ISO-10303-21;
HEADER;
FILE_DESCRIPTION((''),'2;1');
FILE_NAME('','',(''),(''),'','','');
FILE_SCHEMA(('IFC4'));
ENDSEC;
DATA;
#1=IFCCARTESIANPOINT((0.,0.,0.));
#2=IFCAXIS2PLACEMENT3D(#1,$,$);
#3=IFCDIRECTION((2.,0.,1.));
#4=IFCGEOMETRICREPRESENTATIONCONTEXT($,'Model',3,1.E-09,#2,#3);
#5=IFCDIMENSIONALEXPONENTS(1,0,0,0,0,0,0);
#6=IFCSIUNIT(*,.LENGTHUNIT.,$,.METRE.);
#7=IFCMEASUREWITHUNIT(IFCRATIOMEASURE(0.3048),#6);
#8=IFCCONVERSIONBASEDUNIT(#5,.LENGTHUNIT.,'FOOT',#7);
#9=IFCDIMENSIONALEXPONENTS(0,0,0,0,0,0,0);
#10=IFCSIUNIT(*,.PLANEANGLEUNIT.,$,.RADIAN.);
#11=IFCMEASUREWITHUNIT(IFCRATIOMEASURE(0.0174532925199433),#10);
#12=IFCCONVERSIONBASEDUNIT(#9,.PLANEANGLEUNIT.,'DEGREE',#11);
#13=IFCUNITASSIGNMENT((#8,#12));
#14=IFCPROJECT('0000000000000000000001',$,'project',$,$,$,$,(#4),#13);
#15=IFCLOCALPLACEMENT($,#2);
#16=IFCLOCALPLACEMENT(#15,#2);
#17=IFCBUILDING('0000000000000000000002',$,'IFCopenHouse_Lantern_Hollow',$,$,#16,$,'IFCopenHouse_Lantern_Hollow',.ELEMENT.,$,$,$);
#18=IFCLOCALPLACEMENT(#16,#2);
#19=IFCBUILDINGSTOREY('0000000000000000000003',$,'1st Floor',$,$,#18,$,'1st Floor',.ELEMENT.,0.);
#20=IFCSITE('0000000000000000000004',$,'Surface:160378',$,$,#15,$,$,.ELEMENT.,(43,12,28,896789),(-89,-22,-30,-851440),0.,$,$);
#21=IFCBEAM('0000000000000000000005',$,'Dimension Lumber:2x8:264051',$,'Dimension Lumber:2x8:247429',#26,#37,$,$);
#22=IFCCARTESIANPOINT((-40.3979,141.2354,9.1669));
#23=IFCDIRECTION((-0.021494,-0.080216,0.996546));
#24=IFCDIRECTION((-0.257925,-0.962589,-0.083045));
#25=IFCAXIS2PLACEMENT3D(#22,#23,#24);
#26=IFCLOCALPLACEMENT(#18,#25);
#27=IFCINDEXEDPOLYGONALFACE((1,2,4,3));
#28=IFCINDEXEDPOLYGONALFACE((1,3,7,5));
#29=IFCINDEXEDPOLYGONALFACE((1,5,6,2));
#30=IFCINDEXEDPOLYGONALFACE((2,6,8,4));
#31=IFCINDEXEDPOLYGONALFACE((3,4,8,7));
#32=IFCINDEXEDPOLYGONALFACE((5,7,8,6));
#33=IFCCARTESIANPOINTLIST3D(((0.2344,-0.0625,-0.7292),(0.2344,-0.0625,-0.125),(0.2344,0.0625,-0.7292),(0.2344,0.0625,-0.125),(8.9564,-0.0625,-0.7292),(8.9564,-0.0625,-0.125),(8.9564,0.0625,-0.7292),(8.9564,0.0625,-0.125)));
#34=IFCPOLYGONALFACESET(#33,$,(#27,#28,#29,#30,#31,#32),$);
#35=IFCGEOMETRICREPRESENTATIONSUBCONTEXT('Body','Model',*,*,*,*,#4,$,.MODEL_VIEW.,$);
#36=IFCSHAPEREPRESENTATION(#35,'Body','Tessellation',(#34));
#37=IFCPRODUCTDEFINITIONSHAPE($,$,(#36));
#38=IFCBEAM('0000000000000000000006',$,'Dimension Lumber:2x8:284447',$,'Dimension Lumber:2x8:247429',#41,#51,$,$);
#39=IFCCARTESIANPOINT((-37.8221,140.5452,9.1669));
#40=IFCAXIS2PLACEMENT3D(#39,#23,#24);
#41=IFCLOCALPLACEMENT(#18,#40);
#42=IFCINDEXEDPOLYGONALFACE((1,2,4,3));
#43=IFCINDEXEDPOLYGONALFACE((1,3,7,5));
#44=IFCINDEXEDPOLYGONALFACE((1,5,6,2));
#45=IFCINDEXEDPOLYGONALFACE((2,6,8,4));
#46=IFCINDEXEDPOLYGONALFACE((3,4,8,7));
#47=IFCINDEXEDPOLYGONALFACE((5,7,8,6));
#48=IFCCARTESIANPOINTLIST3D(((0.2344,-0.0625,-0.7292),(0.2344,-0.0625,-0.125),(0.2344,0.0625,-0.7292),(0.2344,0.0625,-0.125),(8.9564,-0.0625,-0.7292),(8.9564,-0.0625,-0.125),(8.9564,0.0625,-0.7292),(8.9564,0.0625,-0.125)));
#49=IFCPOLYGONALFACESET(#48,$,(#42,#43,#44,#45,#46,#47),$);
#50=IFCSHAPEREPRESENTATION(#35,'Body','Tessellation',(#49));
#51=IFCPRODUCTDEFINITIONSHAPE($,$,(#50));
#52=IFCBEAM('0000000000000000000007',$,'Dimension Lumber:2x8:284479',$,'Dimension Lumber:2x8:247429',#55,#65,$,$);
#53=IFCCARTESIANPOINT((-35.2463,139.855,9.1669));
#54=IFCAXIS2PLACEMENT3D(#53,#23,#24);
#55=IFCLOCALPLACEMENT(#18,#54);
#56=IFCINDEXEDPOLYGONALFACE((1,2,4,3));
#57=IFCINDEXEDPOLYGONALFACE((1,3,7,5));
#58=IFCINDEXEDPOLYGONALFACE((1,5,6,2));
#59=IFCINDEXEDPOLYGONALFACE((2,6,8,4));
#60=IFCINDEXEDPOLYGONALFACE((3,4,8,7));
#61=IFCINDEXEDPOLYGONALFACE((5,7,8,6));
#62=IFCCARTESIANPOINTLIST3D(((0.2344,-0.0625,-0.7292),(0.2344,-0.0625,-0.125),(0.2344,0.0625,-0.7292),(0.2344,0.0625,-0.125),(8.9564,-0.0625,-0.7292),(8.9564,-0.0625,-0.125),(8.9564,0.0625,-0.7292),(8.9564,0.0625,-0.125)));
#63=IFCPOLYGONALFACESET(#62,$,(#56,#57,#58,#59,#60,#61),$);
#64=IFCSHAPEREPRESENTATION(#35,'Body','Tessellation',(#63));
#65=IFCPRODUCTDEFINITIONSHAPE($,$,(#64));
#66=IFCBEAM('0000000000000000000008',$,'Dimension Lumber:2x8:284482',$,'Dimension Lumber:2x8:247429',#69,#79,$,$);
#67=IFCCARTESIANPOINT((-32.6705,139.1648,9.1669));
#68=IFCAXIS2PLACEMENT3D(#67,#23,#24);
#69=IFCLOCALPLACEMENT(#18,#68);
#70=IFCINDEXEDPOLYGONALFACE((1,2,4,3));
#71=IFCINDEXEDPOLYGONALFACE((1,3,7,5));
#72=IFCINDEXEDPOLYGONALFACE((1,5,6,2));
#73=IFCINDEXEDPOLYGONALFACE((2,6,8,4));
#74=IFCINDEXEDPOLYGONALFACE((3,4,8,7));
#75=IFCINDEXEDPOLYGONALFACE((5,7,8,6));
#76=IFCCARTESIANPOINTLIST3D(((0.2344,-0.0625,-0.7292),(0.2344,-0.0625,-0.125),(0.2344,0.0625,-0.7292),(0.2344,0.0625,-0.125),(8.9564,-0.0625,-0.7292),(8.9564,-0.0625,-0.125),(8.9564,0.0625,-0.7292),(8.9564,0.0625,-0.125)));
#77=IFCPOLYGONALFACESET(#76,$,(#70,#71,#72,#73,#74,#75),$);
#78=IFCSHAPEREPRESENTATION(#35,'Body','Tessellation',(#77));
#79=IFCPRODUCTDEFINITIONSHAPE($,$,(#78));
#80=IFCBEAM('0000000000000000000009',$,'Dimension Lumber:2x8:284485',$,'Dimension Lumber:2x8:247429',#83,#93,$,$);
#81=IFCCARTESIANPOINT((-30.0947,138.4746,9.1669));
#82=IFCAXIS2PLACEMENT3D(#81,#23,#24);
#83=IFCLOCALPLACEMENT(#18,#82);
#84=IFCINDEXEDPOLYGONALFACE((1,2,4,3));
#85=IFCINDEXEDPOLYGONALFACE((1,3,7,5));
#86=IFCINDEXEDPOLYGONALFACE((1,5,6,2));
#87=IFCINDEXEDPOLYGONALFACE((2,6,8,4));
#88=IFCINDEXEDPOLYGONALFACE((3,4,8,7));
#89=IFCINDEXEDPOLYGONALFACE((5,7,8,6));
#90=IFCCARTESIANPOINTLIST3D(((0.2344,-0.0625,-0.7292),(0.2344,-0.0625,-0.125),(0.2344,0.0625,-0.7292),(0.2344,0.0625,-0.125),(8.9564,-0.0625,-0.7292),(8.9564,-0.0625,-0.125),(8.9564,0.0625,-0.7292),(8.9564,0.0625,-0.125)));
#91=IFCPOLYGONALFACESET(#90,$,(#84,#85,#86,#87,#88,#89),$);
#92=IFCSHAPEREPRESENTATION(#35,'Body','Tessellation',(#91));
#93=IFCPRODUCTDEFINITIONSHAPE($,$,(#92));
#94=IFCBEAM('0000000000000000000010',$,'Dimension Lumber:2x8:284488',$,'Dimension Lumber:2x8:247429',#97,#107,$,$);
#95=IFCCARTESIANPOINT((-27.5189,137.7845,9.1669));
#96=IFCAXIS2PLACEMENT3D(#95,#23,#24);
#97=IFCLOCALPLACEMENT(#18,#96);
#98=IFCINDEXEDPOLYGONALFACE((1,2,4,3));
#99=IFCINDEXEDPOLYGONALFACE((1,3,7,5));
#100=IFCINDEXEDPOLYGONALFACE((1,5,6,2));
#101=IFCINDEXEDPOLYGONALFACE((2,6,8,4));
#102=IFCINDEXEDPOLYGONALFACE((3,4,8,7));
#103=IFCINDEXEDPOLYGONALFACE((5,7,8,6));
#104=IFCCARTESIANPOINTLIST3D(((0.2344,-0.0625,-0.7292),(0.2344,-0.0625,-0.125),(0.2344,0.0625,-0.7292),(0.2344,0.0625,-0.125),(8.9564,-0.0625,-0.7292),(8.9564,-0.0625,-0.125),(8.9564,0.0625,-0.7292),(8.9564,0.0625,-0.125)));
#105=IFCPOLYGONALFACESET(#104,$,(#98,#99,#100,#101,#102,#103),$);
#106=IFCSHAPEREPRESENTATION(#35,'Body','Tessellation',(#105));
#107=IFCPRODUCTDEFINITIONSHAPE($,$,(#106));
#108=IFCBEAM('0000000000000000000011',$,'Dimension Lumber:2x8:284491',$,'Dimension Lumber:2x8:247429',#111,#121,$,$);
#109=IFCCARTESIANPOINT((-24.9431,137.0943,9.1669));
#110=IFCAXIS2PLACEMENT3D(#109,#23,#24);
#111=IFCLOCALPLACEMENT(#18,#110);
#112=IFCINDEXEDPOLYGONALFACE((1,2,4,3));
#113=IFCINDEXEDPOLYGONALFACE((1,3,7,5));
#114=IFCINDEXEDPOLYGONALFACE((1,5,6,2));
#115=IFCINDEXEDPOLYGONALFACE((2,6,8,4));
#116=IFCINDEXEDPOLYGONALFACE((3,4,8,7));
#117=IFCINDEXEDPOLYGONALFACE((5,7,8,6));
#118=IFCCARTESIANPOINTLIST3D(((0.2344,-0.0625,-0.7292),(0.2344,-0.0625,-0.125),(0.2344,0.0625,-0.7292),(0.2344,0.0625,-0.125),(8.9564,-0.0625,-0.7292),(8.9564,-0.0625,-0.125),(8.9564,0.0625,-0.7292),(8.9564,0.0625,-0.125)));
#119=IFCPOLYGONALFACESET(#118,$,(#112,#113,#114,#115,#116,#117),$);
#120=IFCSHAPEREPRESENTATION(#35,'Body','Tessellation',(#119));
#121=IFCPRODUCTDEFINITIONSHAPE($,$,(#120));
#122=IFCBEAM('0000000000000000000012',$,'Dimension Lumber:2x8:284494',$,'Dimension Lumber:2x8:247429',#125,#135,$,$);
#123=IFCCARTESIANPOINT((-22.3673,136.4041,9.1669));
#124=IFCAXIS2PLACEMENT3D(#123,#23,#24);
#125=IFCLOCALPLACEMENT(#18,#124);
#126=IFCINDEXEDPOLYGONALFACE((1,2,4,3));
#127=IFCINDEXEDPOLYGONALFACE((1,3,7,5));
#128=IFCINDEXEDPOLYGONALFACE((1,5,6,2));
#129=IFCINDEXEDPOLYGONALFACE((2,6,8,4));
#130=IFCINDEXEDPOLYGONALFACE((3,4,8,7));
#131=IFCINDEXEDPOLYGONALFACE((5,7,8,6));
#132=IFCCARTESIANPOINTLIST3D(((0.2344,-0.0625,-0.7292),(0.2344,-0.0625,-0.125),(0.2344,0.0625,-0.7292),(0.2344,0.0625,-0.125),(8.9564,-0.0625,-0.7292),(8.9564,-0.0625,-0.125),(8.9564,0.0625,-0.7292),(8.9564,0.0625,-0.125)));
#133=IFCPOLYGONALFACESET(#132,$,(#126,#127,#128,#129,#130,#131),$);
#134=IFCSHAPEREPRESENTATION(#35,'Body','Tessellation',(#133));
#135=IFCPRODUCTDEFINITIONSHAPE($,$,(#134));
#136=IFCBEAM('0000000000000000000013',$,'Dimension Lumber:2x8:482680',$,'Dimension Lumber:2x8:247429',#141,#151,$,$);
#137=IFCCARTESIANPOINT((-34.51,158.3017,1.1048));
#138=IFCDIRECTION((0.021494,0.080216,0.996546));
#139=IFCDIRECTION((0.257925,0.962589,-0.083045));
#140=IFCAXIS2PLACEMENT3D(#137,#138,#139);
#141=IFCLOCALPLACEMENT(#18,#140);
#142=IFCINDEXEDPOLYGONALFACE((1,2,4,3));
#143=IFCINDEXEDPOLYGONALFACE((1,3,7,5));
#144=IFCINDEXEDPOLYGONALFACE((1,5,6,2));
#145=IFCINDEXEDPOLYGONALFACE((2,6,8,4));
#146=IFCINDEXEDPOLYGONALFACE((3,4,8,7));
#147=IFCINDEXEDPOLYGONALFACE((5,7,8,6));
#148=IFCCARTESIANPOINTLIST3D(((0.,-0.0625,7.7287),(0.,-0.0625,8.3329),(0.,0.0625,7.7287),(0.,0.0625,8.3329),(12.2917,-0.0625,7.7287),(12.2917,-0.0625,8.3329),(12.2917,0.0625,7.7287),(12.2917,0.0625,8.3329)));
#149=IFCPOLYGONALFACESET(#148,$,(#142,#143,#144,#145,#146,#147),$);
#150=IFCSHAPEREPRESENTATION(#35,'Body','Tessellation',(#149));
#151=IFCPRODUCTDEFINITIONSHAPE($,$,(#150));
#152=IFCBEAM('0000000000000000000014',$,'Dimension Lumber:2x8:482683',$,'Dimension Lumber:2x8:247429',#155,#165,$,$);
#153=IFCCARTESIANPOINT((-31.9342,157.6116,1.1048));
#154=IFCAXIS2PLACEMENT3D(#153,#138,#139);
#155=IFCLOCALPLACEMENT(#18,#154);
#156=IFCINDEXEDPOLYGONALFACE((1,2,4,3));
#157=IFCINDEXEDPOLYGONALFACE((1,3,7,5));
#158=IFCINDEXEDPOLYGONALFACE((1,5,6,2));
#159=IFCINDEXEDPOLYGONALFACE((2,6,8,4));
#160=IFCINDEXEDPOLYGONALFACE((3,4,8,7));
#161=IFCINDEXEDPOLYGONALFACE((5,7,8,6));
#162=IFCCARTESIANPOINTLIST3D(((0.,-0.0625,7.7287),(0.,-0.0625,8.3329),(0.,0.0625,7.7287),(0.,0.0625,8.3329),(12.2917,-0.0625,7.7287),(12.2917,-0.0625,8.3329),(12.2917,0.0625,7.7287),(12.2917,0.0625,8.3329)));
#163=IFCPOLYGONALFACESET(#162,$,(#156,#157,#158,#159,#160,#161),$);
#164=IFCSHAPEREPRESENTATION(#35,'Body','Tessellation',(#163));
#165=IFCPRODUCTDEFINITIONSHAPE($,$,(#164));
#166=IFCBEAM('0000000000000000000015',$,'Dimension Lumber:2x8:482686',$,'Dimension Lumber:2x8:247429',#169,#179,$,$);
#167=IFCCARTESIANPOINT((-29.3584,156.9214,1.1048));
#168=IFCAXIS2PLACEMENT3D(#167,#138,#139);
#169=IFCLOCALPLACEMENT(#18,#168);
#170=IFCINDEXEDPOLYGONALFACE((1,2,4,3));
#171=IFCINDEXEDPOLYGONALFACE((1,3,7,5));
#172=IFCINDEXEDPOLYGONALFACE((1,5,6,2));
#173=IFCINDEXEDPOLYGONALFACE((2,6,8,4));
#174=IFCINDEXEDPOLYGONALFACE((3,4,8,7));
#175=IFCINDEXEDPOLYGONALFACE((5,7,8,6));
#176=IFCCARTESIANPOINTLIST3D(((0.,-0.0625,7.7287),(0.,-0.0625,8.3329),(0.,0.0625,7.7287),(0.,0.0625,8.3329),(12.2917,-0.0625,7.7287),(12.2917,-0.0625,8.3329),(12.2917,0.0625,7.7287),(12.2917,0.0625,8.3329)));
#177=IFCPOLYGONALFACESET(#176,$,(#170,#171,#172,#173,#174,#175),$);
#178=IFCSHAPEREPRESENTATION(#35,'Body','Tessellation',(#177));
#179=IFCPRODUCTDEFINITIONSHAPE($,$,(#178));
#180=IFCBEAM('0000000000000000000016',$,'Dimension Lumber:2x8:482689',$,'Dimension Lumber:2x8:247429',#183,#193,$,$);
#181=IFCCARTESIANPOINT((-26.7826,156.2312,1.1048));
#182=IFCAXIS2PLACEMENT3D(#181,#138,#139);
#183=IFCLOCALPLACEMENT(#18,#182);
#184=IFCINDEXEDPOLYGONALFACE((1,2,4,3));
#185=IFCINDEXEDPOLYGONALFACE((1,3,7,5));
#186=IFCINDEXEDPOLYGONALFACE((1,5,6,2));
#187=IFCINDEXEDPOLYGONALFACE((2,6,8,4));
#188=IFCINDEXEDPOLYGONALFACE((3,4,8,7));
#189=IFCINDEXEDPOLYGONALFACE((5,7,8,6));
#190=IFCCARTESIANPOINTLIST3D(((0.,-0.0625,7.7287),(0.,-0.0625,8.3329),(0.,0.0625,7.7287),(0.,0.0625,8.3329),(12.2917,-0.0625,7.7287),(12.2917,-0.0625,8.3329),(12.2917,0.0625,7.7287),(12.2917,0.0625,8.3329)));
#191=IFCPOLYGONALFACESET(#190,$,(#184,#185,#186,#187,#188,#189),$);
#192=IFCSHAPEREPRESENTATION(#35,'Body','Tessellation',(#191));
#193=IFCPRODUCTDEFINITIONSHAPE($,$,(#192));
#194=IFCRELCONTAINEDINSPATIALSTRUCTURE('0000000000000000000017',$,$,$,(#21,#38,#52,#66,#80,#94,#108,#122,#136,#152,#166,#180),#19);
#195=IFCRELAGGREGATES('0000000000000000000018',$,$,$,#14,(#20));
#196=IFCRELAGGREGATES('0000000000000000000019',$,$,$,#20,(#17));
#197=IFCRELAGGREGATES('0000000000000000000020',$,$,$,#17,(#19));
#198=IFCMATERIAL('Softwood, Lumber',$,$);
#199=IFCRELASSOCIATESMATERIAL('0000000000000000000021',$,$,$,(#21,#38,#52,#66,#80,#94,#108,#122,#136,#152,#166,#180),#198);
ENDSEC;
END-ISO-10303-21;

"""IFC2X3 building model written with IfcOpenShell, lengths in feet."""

from ifc_helpers import new_model, entity, si_unit, converted_unit, direction, frame, frame_2d, origin, place, context, subcontext, project, spatial, rectangle, extrude, material, element, save


model = new_model("IFC2X3")

# Units and contexts
model_context = context("Model", 3, precision=1e-09, world=origin(), true_north=direction((2.0, 0.0, 1.0)))
body_context = subcontext(model_context, "Body", "Model", "MODEL_VIEW")
ifc_project = project(units=[converted_unit("LENGTHUNIT", "FOOT", entity("IfcRatioMeasure", 0.3048), si_unit("LENGTHUNIT", "METRE"), dimensions=[1, 0, 0, 0, 0, 0, 0]), converted_unit("PLANEANGLEUNIT", "DEGREE", entity("IfcRatioMeasure", 0.0174532925199433), si_unit("PLANEANGLEUNIT", "RADIAN"), dimensions=[0, 0, 0, 0, 0, 0, 0])], contexts=[model_context])

# Site, building, storey
site_placement = place(None, origin())
site = spatial("IfcSite", under=ifc_project, at=site_placement, Name="Surface:160378", CompositionType="ELEMENT", RefLatitude=(43, 12, 28, 896789), RefLongitude=(-89, -22, -30, -851440), RefElevation=0.0)
building_placement = place(site_placement, origin())
building = spatial("IfcBuilding", under=site, at=building_placement, Name="IFCopenHouse_Lantern_Hollow", LongName="IFCopenHouse_Lantern_Hollow", CompositionType="ELEMENT")
storey_placement = place(building_placement, origin())
storey = spatial("IfcBuildingStorey", under=building, at=storey_placement, Name="1st Floor", LongName="1st Floor", CompositionType="ELEMENT", Elevation=0.0)

# Beams
ifc_material_1 = material(Name="Softwood, Lumber")
beam_1_placement = place(storey_placement, frame((-40.3979, 141.2354, 9.1669), z_axis=(-0.021494, -0.080216, 0.996546), x_axis=(-0.257925, -0.962589, -0.083045)))
element("IfcBeam", 1, at=beam_1_placement, inside=storey, material=ifc_material_1, Name="Dimension Lumber:2x8:264051", ObjectType="Dimension Lumber:2x8:247429", context=body_context, shape_type="SweptSolid", body=[
    extrude(rectangle(XDim=0.6042, YDim=0.125, at=frame_2d((0.0, 0.0), x_axis=(1.0, 0.0))), frame((0.2344, 0.0, -0.4271), z_axis=(1.0, 0.0, 0.0), x_axis=(0.0, 0.0, -1.0)), (0.0, 0.0, 1.0), 8.722),
])
beam_2_placement = place(storey_placement, frame((-37.8221, 140.5452, 9.1669), z_axis=(-0.021494, -0.080216, 0.996546), x_axis=(-0.257925, -0.962589, -0.083045)))
element("IfcBeam", 2, at=beam_2_placement, inside=storey, material=ifc_material_1, Name="Dimension Lumber:2x8:284447", ObjectType="Dimension Lumber:2x8:247429", context=body_context, shape_type="SweptSolid", body=[
    extrude(rectangle(XDim=0.6042, YDim=0.125, at=frame_2d((0.0, 0.0), x_axis=(1.0, 0.0))), frame((0.2344, 0.0, -0.4271), z_axis=(1.0, 0.0, 0.0), x_axis=(0.0, 0.0, -1.0)), (0.0, 0.0, 1.0), 8.722),
])
beam_3_placement = place(storey_placement, frame((-35.2463, 139.855, 9.1669), z_axis=(-0.021494, -0.080216, 0.996546), x_axis=(-0.257925, -0.962589, -0.083045)))
element("IfcBeam", 3, at=beam_3_placement, inside=storey, material=ifc_material_1, Name="Dimension Lumber:2x8:284479", ObjectType="Dimension Lumber:2x8:247429", context=body_context, shape_type="SweptSolid", body=[
    extrude(rectangle(XDim=0.6042, YDim=0.125, at=frame_2d((0.0, 0.0), x_axis=(1.0, 0.0))), frame((0.2344, 0.0, -0.4271), z_axis=(1.0, 0.0, 0.0), x_axis=(0.0, 0.0, -1.0)), (0.0, 0.0, 1.0), 8.722),
])
beam_4_placement = place(storey_placement, frame((-32.6705, 139.1648, 9.1669), z_axis=(-0.021494, -0.080216, 0.996546), x_axis=(-0.257925, -0.962589, -0.083045)))
element("IfcBeam", 4, at=beam_4_placement, inside=storey, material=ifc_material_1, Name="Dimension Lumber:2x8:284482", ObjectType="Dimension Lumber:2x8:247429", context=body_context, shape_type="SweptSolid", body=[
    extrude(rectangle(XDim=0.6042, YDim=0.125, at=frame_2d((0.0, 0.0), x_axis=(1.0, 0.0))), frame((0.2344, 0.0, -0.4271), z_axis=(1.0, 0.0, 0.0), x_axis=(0.0, 0.0, -1.0)), (0.0, 0.0, 1.0), 8.722),
])
beam_5_placement = place(storey_placement, frame((-30.0947, 138.4746, 9.1669), z_axis=(-0.021494, -0.080216, 0.996546), x_axis=(-0.257925, -0.962589, -0.083045)))
element("IfcBeam", 5, at=beam_5_placement, inside=storey, material=ifc_material_1, Name="Dimension Lumber:2x8:284485", ObjectType="Dimension Lumber:2x8:247429", context=body_context, shape_type="SweptSolid", body=[
    extrude(rectangle(XDim=0.6042, YDim=0.125, at=frame_2d((0.0, 0.0), x_axis=(1.0, 0.0))), frame((0.2344, 0.0, -0.4271), z_axis=(1.0, 0.0, 0.0), x_axis=(0.0, 0.0, -1.0)), (0.0, 0.0, 1.0), 8.722),
])
beam_6_placement = place(storey_placement, frame((-27.5189, 137.7845, 9.1669), z_axis=(-0.021494, -0.080216, 0.996546), x_axis=(-0.257925, -0.962589, -0.083045)))
element("IfcBeam", 6, at=beam_6_placement, inside=storey, material=ifc_material_1, Name="Dimension Lumber:2x8:284488", ObjectType="Dimension Lumber:2x8:247429", context=body_context, shape_type="SweptSolid", body=[
    extrude(rectangle(XDim=0.6042, YDim=0.125, at=frame_2d((0.0, 0.0), x_axis=(1.0, 0.0))), frame((0.2344, 0.0, -0.4271), z_axis=(1.0, 0.0, 0.0), x_axis=(0.0, 0.0, -1.0)), (0.0, 0.0, 1.0), 8.722),
])
beam_7_placement = place(storey_placement, frame((-24.9431, 137.0943, 9.1669), z_axis=(-0.021494, -0.080216, 0.996546), x_axis=(-0.257925, -0.962589, -0.083045)))
element("IfcBeam", 7, at=beam_7_placement, inside=storey, material=ifc_material_1, Name="Dimension Lumber:2x8:284491", ObjectType="Dimension Lumber:2x8:247429", context=body_context, shape_type="SweptSolid", body=[
    extrude(rectangle(XDim=0.6042, YDim=0.125, at=frame_2d((0.0, 0.0), x_axis=(1.0, 0.0))), frame((0.2344, 0.0, -0.4271), z_axis=(1.0, 0.0, 0.0), x_axis=(0.0, 0.0, -1.0)), (0.0, 0.0, 1.0), 8.722),
])
beam_8_placement = place(storey_placement, frame((-22.3673, 136.4041, 9.1669), z_axis=(-0.021494, -0.080216, 0.996546), x_axis=(-0.257925, -0.962589, -0.083045)))
element("IfcBeam", 8, at=beam_8_placement, inside=storey, material=ifc_material_1, Name="Dimension Lumber:2x8:284494", ObjectType="Dimension Lumber:2x8:247429", context=body_context, shape_type="SweptSolid", body=[
    extrude(rectangle(XDim=0.6042, YDim=0.125, at=frame_2d((0.0, 0.0), x_axis=(1.0, 0.0))), frame((0.2344, 0.0, -0.4271), z_axis=(1.0, 0.0, 0.0), x_axis=(0.0, 0.0, -1.0)), (0.0, 0.0, 1.0), 8.722),
])
beam_9_placement = place(storey_placement, frame((-34.51, 158.3017, 1.1048), z_axis=(0.021494, 0.080216, 0.996546), x_axis=(0.257925, 0.962589, -0.083045)))
element("IfcBeam", 9, at=beam_9_placement, inside=storey, material=ifc_material_1, Name="Dimension Lumber:2x8:482680", ObjectType="Dimension Lumber:2x8:247429", context=body_context, shape_type="SweptSolid", body=[
    extrude(rectangle(XDim=0.6042, YDim=0.125, at=frame_2d((0.0, 0.0), x_axis=(1.0, 0.0))), frame((0.0, 0.0, 8.0308), z_axis=(1.0, 0.0, 0.0), x_axis=(0.0, 0.0, -1.0)), (0.0, 0.0, 1.0), 12.2917),
])
beam_10_placement = place(storey_placement, frame((-31.9342, 157.6116, 1.1048), z_axis=(0.021494, 0.080216, 0.996546), x_axis=(0.257925, 0.962589, -0.083045)))
element("IfcBeam", 10, at=beam_10_placement, inside=storey, material=ifc_material_1, Name="Dimension Lumber:2x8:482683", ObjectType="Dimension Lumber:2x8:247429", context=body_context, shape_type="SweptSolid", body=[
    extrude(rectangle(XDim=0.6042, YDim=0.125, at=frame_2d((0.0, 0.0), x_axis=(1.0, 0.0))), frame((0.0, 0.0, 8.0308), z_axis=(1.0, 0.0, 0.0), x_axis=(0.0, 0.0, -1.0)), (0.0, 0.0, 1.0), 12.2917),
])
beam_11_placement = place(storey_placement, frame((-29.3584, 156.9214, 1.1048), z_axis=(0.021494, 0.080216, 0.996546), x_axis=(0.257925, 0.962589, -0.083045)))
element("IfcBeam", 11, at=beam_11_placement, inside=storey, material=ifc_material_1, Name="Dimension Lumber:2x8:482686", ObjectType="Dimension Lumber:2x8:247429", context=body_context, shape_type="SweptSolid", body=[
    extrude(rectangle(XDim=0.6042, YDim=0.125, at=frame_2d((0.0, 0.0), x_axis=(1.0, 0.0))), frame((0.0, 0.0, 8.0308), z_axis=(1.0, 0.0, 0.0), x_axis=(0.0, 0.0, -1.0)), (0.0, 0.0, 1.0), 12.2917),
])
beam_12_placement = place(storey_placement, frame((-26.7826, 156.2312, 1.1048), z_axis=(0.021494, 0.080216, 0.996546), x_axis=(0.257925, 0.962589, -0.083045)))
element("IfcBeam", 12, at=beam_12_placement, inside=storey, material=ifc_material_1, Name="Dimension Lumber:2x8:482689", ObjectType="Dimension Lumber:2x8:247429", context=body_context, shape_type="SweptSolid", body=[
    extrude(rectangle(XDim=0.6042, YDim=0.125, at=frame_2d((0.0, 0.0), x_axis=(1.0, 0.0))), frame((0.0, 0.0, 8.0308), z_axis=(1.0, 0.0, 0.0), x_axis=(0.0, 0.0, -1.0)), (0.0, 0.0, 1.0), 12.2917),
])

save(model, "model.ifc")
